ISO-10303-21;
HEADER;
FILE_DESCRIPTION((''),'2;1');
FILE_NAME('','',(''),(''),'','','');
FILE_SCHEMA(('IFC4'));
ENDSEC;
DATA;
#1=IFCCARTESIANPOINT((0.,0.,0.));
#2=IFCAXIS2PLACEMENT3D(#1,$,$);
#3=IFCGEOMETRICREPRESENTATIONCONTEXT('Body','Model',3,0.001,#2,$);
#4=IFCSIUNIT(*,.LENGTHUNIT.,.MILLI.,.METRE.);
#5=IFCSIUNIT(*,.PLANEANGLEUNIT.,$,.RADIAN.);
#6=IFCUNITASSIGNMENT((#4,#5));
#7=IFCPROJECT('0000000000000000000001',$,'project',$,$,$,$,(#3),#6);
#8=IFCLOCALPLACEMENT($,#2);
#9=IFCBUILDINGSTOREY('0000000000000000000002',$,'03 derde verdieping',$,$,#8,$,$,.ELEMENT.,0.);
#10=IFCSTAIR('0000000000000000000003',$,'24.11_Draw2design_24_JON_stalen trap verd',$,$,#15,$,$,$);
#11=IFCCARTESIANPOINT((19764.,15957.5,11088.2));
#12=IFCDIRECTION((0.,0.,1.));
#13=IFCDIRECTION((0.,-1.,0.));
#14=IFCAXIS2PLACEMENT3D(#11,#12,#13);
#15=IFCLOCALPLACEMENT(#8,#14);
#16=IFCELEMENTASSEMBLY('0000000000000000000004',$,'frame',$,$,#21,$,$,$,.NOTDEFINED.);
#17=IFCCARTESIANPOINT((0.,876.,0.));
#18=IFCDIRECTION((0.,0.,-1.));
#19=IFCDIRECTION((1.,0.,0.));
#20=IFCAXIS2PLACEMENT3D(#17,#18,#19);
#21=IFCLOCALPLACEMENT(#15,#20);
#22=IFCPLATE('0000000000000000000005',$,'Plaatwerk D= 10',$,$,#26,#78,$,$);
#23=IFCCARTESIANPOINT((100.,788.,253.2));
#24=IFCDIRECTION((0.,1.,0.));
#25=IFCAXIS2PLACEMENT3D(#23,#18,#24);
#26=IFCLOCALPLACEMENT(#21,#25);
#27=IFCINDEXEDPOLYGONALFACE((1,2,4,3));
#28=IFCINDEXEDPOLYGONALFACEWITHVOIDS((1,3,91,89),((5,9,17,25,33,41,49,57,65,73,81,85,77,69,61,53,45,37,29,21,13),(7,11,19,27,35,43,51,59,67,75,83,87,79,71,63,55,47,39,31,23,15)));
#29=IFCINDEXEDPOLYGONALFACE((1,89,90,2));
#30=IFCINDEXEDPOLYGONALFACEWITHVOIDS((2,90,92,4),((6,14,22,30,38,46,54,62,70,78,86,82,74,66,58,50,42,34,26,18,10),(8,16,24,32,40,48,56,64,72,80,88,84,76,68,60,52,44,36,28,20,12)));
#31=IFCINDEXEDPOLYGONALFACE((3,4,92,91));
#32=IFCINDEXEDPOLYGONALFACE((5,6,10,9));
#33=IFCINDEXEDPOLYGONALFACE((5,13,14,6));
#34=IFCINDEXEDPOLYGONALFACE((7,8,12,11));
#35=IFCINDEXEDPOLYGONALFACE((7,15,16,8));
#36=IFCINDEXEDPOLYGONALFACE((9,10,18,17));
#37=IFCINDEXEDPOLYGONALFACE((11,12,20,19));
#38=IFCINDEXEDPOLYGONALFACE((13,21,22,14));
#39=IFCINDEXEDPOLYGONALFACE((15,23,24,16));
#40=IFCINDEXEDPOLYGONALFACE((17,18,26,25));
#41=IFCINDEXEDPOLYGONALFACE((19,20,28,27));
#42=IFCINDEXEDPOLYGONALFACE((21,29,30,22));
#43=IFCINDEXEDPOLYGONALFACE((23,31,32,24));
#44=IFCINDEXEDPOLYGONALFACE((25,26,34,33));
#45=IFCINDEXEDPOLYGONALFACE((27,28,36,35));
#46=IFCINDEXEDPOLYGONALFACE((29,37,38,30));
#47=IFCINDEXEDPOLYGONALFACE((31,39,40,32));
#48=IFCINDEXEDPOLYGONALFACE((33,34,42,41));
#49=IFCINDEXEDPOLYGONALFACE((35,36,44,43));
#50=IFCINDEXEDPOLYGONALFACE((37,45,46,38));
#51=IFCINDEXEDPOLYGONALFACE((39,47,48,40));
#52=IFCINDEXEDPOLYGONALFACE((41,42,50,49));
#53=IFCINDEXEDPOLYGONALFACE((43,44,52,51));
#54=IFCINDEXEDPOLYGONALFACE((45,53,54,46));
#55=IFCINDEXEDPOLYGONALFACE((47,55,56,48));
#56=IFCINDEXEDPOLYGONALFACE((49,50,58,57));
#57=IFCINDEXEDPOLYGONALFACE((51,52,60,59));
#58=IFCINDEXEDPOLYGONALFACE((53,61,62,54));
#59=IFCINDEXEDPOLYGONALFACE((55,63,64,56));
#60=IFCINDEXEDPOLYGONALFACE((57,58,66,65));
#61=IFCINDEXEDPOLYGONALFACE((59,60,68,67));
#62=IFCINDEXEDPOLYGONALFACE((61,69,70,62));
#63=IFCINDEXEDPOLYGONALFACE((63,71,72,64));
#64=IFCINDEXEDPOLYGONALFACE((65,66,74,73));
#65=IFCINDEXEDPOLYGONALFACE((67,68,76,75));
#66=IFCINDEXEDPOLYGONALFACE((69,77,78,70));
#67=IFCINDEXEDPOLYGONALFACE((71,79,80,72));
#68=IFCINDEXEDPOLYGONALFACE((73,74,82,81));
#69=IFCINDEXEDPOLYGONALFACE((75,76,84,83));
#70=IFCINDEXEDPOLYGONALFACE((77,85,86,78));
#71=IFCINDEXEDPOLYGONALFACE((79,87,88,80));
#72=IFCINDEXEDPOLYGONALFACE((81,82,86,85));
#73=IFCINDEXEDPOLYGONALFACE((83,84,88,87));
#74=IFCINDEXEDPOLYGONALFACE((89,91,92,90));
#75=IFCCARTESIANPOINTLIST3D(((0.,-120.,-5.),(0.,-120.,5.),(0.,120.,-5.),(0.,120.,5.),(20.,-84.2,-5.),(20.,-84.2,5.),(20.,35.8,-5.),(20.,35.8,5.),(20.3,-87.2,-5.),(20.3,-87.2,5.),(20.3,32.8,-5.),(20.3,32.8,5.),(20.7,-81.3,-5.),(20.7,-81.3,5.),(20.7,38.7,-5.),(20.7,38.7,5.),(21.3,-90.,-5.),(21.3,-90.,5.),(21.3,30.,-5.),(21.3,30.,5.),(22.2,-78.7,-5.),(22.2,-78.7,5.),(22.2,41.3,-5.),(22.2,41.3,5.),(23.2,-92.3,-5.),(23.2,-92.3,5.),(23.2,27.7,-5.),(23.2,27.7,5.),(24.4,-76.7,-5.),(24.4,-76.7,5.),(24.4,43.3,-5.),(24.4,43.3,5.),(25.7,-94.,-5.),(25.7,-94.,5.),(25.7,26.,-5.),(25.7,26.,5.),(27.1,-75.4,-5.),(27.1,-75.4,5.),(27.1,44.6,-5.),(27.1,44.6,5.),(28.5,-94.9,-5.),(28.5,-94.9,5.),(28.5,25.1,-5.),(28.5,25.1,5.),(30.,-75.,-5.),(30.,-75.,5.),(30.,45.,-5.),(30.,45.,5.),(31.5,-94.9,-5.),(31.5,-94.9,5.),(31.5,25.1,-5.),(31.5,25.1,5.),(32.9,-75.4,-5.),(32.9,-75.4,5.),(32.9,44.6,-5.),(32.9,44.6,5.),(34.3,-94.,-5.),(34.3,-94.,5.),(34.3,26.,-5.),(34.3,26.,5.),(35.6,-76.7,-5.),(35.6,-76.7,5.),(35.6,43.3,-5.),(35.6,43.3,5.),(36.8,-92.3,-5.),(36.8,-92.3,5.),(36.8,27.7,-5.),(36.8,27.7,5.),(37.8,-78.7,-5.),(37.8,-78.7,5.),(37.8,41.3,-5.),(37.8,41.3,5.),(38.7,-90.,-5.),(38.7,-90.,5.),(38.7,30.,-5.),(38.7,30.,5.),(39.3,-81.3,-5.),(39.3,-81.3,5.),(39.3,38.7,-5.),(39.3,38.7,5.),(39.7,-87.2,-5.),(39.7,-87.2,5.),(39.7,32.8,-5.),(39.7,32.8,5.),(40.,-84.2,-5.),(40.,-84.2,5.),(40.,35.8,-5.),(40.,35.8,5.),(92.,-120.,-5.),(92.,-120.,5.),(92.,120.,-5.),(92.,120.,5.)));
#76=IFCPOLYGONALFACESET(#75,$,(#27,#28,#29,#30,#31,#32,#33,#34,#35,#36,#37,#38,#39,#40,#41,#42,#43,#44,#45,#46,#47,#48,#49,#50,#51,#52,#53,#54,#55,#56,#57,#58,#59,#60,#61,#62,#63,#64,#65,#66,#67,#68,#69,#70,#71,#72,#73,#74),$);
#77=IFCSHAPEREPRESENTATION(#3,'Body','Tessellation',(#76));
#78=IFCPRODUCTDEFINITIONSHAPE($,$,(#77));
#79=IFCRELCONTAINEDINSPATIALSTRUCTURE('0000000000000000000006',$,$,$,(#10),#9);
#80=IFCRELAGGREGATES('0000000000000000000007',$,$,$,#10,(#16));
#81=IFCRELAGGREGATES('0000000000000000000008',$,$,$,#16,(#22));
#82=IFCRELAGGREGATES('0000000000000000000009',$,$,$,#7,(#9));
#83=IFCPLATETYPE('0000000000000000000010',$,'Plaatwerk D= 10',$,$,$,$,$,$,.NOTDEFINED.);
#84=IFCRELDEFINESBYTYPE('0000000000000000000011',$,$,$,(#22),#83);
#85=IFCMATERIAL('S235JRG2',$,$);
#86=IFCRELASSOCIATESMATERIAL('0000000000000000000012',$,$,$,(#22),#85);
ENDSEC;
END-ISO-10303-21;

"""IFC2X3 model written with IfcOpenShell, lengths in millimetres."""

from ifc_helpers import new_model, si_unit, frame, origin, origin_2d, place, context, project, spatial, rectangle, circle, extrude, source, transform, mapped, material, type_object, element, aggregate, save


model = new_model("IFC2X3")

# Units and contexts
model_context = context("Model", 3, precision=0.001, world=origin(), identifier="Body")
ifc_project = project(units=[si_unit("LENGTHUNIT", "METRE", prefix="MILLI"), si_unit("PLANEANGLEUNIT", "RADIAN")], contexts=[model_context])

# Storey
storey_placement = place(None, origin())
storey = spatial("IfcBuildingStorey", under=ifc_project, at=storey_placement, Name="03 derde verdieping", CompositionType="ELEMENT", Elevation=0.0)

# Shared definitions
ifc_material_1 = material(Name="S235JRG2")

# Stair
stair_placement = place(storey_placement, frame((19764.0, 15957.5, 11088.2), z_axis=(0.0, 0.0, 1.0), x_axis=(0.0, -1.0, 0.0)))
stair = element("IfcStair", 1, at=stair_placement, inside=storey, Name="24.11_Draw2design_24_JON_stalen trap verd")

# Element assembly
assembly_placement = place(stair_placement, frame((0.0, 876.0, 0.0), z_axis=(0.0, 0.0, -1.0), x_axis=(1.0, 0.0, 0.0)))
assembly = element("IfcElementAssembly", 2, at=assembly_placement, Name="frame", PredefinedType="NOTDEFINED")
aggregate(stair, [assembly])

# Plate, openings
plate_type = type_object("IfcPlateType", Name="Plaatwerk D= 10")
shared_shape_1 = source(origin(), model_context, "Body", "SweptSolid", [
    extrude(rectangle(XDim=92.0, YDim=240.0, at=origin_2d()), frame((46.0, 0.0, -5.0)), (0.0, 0.0, 1.0), 10.0),
])
plate_1_placement = place(assembly_placement, frame((100.0, 788.0, 253.2), z_axis=(0.0, 0.0, -1.0), x_axis=(0.0, 1.0, 0.0)))
plate_1 = element("IfcPlate", 3, at=plate_1_placement, type_object=plate_type, material=ifc_material_1, Name="Plaatwerk D= 10", context=model_context, shape_type="MappedRepresentation", body=[
    mapped(shared_shape_1, transform((0.0, 0.0, 0.0), scale=1.0)),
])
opening_1_placement = place(plate_1_placement, frame((30.0, -85.0, 5.0), z_axis=(0.0, 0.0, -1.0), x_axis=(0.0, 1.0, 0.0)))
element("IfcOpeningElement", 4, at=opening_1_placement, cuts=plate_1, ObjectType="Opening", context=model_context, shape_type="SweptSolid", body=[
    extrude(circle(Radius=10.0, at=origin_2d()), origin(), (0.0, 0.0, 1.0), 10.0),
])
opening_2_placement = place(plate_1_placement, frame((30.0, 35.0, 5.0), z_axis=(0.0, 0.0, -1.0), x_axis=(0.0, 1.0, 0.0)))
element("IfcOpeningElement", 5, at=opening_2_placement, cuts=plate_1, ObjectType="Opening", context=model_context, shape_type="SweptSolid", body=[
    extrude(circle(Radius=10.0, at=origin_2d()), origin(), (0.0, 0.0, 1.0), 10.0),
])
aggregate(assembly, [plate_1])

save(model, "model.ifc")
